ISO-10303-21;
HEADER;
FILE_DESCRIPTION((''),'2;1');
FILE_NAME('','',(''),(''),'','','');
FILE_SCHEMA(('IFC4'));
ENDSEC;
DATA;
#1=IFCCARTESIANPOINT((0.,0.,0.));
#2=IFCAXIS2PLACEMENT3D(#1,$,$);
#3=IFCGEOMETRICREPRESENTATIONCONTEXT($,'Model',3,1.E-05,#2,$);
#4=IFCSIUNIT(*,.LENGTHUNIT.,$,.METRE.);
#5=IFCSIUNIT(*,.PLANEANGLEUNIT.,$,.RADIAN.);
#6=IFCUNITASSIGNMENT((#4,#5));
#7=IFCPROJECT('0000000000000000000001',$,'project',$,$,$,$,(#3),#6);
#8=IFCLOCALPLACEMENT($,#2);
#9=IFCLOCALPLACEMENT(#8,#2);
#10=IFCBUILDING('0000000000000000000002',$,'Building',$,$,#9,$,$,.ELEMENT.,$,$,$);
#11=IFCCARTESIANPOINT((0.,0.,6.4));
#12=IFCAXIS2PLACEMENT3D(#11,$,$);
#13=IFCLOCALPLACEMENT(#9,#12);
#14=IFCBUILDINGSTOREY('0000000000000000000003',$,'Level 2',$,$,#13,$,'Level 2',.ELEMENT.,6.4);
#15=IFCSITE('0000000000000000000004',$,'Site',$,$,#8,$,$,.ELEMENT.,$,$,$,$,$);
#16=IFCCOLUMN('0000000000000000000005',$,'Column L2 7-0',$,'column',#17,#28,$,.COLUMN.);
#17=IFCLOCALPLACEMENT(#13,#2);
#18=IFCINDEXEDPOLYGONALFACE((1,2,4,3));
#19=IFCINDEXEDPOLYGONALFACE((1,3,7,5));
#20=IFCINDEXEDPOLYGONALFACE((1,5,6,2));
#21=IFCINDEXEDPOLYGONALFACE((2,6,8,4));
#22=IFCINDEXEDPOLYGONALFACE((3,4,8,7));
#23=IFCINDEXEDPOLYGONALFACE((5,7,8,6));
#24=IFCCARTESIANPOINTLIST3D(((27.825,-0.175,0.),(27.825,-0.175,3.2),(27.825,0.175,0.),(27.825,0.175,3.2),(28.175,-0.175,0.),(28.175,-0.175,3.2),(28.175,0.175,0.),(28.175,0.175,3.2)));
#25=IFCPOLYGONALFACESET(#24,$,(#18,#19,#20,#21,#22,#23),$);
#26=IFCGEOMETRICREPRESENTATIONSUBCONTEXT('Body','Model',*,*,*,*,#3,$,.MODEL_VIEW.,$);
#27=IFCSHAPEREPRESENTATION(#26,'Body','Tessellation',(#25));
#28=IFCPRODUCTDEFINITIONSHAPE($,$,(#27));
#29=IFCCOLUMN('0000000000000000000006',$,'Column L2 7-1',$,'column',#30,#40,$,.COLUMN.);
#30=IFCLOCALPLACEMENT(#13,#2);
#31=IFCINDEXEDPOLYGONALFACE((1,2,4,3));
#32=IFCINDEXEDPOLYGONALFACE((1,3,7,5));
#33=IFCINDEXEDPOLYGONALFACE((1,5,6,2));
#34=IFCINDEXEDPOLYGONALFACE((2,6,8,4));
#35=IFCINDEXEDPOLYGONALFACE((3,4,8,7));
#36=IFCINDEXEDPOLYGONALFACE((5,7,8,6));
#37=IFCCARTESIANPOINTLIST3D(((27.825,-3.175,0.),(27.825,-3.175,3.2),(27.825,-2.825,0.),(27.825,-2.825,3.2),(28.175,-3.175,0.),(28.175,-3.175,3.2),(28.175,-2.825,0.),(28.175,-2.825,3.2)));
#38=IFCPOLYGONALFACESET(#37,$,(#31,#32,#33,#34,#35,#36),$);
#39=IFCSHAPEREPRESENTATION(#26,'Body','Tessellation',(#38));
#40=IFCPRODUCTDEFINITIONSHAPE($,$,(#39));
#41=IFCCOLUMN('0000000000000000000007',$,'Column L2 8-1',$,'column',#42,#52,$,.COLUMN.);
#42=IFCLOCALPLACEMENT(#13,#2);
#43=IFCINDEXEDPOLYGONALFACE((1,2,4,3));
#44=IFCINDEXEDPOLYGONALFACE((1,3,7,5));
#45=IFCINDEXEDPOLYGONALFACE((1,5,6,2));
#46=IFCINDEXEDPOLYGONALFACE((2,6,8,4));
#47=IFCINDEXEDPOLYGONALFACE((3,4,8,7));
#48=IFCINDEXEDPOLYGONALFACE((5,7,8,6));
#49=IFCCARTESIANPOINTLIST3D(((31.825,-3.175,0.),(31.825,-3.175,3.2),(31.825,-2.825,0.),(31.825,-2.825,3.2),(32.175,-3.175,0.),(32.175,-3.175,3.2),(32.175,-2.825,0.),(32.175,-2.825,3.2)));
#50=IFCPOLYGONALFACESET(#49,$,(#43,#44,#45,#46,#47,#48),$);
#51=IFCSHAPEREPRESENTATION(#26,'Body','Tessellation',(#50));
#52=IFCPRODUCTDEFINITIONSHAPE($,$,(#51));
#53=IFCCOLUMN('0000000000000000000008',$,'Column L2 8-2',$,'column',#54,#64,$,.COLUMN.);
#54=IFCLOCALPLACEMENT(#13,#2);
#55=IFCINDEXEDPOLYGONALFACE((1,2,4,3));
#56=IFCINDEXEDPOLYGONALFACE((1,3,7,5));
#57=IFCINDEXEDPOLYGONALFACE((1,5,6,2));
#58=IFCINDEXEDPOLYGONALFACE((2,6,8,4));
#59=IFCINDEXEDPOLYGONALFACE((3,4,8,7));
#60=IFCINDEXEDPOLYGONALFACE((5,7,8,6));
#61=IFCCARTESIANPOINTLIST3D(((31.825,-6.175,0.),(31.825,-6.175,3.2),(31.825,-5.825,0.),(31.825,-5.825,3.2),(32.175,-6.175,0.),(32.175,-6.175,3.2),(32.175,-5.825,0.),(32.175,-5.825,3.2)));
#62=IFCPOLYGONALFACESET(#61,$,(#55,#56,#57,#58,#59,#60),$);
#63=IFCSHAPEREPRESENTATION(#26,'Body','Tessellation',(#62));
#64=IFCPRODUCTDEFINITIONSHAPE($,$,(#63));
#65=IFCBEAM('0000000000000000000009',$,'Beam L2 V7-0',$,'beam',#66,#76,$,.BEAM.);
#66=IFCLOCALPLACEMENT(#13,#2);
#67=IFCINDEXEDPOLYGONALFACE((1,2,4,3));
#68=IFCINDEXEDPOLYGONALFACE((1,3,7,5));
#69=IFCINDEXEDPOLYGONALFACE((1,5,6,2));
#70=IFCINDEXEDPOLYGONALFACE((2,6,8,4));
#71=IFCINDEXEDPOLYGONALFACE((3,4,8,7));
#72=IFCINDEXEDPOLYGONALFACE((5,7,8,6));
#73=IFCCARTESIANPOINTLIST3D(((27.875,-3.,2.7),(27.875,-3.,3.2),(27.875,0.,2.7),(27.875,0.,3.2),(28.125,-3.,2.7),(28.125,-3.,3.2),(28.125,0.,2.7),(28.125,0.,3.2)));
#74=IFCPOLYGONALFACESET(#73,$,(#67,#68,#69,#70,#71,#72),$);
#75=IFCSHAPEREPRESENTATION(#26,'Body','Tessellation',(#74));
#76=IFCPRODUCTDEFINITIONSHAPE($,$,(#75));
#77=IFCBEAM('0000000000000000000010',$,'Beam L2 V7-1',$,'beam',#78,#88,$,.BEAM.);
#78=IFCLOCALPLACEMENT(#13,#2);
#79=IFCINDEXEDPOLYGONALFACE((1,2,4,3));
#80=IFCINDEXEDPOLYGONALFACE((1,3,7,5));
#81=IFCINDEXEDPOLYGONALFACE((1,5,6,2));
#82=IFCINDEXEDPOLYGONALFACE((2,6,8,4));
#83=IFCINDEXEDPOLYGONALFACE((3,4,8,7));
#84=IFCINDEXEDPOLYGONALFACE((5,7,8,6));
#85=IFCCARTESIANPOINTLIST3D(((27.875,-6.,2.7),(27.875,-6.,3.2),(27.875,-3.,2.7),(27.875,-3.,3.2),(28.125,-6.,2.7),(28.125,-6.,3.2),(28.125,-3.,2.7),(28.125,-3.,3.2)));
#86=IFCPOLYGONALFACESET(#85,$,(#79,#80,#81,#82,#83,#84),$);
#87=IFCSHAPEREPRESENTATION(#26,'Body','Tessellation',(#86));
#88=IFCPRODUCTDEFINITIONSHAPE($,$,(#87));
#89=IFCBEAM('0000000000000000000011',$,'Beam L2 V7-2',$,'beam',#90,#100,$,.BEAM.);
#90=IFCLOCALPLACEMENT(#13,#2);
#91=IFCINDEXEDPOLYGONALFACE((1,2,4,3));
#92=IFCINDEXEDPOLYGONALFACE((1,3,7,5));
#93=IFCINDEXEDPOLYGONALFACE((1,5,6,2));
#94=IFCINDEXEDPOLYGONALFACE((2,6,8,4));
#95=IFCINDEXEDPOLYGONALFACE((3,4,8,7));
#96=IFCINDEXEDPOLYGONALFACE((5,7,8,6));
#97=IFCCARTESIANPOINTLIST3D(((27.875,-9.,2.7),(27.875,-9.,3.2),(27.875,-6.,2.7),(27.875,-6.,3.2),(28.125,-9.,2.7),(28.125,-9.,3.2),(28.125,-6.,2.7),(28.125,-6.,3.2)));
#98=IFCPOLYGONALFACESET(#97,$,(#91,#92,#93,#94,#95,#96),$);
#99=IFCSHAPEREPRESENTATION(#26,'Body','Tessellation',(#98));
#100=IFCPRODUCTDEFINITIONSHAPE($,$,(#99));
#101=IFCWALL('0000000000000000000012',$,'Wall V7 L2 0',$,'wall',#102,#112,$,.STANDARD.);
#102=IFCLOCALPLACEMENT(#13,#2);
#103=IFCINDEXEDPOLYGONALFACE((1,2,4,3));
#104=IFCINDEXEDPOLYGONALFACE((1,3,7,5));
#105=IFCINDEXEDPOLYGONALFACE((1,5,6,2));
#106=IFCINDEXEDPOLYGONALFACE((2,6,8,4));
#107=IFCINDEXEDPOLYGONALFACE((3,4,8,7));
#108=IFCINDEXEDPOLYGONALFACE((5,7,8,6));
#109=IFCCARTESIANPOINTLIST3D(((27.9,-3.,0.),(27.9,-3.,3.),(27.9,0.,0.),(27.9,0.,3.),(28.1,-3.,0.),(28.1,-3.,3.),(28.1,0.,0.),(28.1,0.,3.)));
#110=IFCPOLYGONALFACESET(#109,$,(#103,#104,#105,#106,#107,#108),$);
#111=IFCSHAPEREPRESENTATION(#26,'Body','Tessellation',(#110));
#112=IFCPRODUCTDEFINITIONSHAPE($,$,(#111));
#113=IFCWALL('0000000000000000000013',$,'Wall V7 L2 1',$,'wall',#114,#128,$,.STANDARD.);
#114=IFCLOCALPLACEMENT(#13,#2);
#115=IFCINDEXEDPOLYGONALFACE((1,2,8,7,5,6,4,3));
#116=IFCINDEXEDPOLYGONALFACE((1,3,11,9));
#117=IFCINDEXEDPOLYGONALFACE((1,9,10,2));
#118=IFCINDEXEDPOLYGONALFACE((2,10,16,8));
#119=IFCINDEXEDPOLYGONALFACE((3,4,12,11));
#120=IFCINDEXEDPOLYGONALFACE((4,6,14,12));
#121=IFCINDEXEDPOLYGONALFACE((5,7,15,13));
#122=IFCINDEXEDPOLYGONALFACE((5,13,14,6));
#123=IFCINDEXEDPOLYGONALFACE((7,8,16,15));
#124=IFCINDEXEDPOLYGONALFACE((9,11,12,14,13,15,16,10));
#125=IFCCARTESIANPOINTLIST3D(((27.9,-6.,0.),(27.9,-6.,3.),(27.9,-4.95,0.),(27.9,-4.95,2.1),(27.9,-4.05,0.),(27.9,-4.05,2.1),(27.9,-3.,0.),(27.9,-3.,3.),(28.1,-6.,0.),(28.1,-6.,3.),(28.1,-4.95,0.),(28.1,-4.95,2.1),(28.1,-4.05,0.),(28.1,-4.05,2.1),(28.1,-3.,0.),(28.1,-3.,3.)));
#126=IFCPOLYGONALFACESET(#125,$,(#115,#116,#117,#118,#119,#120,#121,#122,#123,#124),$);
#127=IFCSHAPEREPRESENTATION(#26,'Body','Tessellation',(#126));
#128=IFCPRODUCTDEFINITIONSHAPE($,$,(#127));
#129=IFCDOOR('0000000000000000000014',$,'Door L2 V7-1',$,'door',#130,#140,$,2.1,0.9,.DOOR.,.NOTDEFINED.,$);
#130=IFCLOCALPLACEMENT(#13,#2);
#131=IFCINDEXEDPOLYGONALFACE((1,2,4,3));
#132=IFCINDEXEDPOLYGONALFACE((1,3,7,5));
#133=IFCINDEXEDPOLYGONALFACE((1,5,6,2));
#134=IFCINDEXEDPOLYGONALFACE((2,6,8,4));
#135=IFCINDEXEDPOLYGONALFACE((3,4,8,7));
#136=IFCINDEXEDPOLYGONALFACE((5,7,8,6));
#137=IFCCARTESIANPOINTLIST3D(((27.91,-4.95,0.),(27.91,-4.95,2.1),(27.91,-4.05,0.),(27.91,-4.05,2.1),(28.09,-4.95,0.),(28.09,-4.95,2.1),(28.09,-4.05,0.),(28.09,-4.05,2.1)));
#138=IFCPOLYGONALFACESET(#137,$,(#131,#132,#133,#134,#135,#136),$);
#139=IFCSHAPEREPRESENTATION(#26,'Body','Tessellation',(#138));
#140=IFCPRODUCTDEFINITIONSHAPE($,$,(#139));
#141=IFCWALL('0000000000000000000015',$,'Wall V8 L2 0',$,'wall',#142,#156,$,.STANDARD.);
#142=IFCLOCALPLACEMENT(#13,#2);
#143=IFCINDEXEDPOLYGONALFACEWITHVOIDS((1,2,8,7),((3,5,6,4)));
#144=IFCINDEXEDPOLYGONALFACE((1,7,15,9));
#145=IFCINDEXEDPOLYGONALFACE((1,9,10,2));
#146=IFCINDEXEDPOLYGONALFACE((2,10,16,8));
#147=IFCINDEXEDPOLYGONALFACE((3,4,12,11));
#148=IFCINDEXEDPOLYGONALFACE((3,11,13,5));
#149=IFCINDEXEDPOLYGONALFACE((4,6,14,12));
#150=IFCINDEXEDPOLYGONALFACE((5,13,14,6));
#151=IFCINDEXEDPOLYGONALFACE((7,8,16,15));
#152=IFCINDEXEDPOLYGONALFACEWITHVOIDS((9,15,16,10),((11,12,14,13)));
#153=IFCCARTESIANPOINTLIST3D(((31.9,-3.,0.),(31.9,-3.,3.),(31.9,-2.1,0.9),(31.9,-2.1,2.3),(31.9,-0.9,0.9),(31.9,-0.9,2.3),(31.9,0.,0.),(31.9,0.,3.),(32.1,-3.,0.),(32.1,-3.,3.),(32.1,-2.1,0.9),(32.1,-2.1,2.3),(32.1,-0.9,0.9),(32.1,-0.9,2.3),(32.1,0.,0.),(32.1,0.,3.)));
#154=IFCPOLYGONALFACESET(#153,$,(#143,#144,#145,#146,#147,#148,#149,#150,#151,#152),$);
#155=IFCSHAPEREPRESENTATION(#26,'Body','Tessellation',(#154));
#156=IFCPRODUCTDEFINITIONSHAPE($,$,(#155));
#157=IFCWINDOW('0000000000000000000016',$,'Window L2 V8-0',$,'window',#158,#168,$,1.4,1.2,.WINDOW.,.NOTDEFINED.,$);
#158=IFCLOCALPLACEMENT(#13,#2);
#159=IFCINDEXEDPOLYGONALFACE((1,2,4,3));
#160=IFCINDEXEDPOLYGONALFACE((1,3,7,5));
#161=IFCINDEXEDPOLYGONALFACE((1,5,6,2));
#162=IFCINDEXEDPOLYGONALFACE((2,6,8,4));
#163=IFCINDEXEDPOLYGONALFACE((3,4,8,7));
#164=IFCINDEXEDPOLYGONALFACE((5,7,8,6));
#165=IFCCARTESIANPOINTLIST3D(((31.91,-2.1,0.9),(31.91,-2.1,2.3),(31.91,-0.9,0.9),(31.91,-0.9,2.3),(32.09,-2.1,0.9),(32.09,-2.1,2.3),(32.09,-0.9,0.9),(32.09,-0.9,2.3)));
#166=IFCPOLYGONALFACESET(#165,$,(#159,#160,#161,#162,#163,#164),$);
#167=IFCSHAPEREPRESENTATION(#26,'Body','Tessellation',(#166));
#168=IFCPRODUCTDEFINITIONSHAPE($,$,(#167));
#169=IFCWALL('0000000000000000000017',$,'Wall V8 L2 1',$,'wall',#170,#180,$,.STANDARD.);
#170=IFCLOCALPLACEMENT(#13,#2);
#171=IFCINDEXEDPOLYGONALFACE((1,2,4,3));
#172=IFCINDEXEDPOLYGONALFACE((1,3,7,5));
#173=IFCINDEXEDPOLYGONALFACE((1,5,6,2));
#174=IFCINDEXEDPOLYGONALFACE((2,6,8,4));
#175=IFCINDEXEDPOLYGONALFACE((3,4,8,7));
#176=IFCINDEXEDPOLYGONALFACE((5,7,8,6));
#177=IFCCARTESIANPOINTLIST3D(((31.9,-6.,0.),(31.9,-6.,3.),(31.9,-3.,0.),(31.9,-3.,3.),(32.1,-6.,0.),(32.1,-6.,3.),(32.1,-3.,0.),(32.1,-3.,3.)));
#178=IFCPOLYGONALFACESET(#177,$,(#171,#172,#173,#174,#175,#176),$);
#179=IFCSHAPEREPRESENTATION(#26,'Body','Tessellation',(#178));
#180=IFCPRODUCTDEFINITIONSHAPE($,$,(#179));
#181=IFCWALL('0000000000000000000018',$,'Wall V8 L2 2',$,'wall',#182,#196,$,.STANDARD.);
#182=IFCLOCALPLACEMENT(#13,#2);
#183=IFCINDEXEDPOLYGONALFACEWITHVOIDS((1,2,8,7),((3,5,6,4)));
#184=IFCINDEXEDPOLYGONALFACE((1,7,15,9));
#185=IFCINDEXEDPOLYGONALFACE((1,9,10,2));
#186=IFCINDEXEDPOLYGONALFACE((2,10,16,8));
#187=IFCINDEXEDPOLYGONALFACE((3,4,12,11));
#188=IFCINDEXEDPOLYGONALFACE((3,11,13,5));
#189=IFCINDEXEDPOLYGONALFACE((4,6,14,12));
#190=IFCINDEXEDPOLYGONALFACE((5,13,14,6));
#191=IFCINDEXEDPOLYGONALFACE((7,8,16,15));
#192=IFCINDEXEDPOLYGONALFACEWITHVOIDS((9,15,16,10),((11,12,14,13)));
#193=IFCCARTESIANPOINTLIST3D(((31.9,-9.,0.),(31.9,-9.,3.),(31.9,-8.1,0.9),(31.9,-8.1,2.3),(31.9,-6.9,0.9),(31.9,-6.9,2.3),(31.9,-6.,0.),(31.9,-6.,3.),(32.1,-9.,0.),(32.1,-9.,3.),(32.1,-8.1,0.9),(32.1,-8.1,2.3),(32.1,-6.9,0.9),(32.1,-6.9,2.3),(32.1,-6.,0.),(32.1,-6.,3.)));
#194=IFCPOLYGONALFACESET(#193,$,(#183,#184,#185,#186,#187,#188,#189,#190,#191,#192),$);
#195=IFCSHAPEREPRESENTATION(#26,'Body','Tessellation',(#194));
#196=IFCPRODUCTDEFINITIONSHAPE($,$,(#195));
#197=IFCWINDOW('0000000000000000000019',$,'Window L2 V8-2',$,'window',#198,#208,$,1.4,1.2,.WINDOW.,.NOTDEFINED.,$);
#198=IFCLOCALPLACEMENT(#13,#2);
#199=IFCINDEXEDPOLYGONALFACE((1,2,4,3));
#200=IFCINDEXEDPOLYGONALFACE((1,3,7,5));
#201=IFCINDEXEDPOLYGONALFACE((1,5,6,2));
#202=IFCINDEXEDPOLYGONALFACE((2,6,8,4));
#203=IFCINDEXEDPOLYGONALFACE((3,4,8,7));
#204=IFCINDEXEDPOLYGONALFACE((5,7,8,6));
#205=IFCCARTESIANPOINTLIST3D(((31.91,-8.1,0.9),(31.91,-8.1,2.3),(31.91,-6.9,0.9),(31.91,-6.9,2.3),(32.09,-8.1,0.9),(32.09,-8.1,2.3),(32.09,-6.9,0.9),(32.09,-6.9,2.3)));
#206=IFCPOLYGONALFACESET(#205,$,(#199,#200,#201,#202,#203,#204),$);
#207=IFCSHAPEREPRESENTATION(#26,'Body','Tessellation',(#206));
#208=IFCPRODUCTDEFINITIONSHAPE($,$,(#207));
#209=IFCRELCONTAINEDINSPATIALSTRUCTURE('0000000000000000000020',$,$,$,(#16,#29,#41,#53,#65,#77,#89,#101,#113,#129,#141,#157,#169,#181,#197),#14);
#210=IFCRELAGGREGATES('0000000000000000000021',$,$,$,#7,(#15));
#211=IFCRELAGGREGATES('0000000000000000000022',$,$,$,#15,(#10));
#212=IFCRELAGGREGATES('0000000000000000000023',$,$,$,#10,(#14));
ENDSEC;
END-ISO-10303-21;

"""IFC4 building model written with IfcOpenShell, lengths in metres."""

from ifc_helpers import new_model, si_unit, frame, frame_2d, origin, origin_2d, place, context, subcontext, project, spatial, rectangle, extrude, element, fill, save


model = new_model("IFC4")

# Units and contexts
model_context = context("Model", 3, precision=1e-05, world=origin())
body_context = subcontext(model_context, "Body", "Model", "MODEL_VIEW")
ifc_project = project(units=[si_unit("LENGTHUNIT", "METRE"), si_unit("PLANEANGLEUNIT", "RADIAN")], contexts=[model_context])

# Site, building, storey
site_placement = place(None, origin())
site = spatial("IfcSite", under=ifc_project, at=site_placement, Name="Site", CompositionType="ELEMENT")
building_placement = place(site_placement, origin())
building = spatial("IfcBuilding", under=site, at=building_placement, Name="Building", CompositionType="ELEMENT")
storey_placement = place(building_placement, frame((0.0, 0.0, 6.4)))
storey = spatial("IfcBuildingStorey", under=building, at=storey_placement, Name="Level 2", LongName="Level 2", CompositionType="ELEMENT", Elevation=6.4)

# Columns
for number, where, name in (
    (1, (28.0, 0.0, 0.0), "Column L2 7-0"),
    (2, (28.0, -3.0, 0.0), "Column L2 7-1"),
    (3, (32.0, -3.0, 0.0), "Column L2 8-1"),
    (4, (32.0, -6.0, 0.0), "Column L2 8-2"),
):
    element("IfcColumn", number, at=place(storey_placement, frame(where)), inside=storey, Name=name, ObjectType="column", PredefinedType="COLUMN", context=body_context, shape_type="SweptSolid", body=[
        extrude(rectangle(XDim=0.35, YDim=0.35, at=origin_2d()), origin(), (0.0, 0.0, 1.0), 3.2),
    ])

# Beams
for number, where, z_axis, x_axis, name in (
    (5, (28.0, 0.0, 2.95), (0.0, -1.0, 0.0), (0.0, 0.0, 1.0), "Beam L2 V7-0"),
    (6, (28.0, -3.0, 2.95), (0.0, -1.0, 0.0), (0.0, 0.0, 1.0), "Beam L2 V7-1"),
    (7, (28.0, -6.0, 2.95), (0.0, -1.0, 0.0), (0.0, 0.0, 1.0), "Beam L2 V7-2"),
):
    element("IfcBeam", number, at=place(storey_placement, frame(where, z_axis=z_axis, x_axis=x_axis)), inside=storey, Name=name, ObjectType="beam", PredefinedType="BEAM", context=body_context, shape_type="SweptSolid", body=[
        extrude(rectangle(XDim=0.5, YDim=0.25, at=origin_2d()), origin(), (0.0, 0.0, 1.0), 3.0),
    ])

# Wall
wall_1_placement = place(storey_placement, frame((28.0, 0.0, 0.0), z_axis=(0.0, 0.0, 1.0), x_axis=(0.0, -1.0, 0.0)))
element("IfcWall", 8, at=wall_1_placement, inside=storey, Name="Wall V7 L2 0", ObjectType="wall", PredefinedType="STANDARD", context=body_context, shape_type="SweptSolid", body=[
    extrude(rectangle(XDim=3.0, YDim=0.2, at=frame_2d((1.5, 0.0))), origin(), (0.0, 0.0, 1.0), 3.0),
])

# Wall, opening, door
wall_2_placement = place(storey_placement, frame((28.0, -3.0, 0.0), z_axis=(0.0, 0.0, 1.0), x_axis=(0.0, -1.0, 0.0)))
wall_2 = element("IfcWall", 9, at=wall_2_placement, inside=storey, Name="Wall V7 L2 1", ObjectType="wall", PredefinedType="STANDARD", context=body_context, shape_type="SweptSolid", body=[
    extrude(rectangle(XDim=3.0, YDim=0.2, at=frame_2d((1.5, 0.0))), origin(), (0.0, 0.0, 1.0), 3.0),
])
opening_1_placement = place(storey_placement, frame((28.0, -4.5, 0.0), z_axis=(0.0, 0.0, 1.0), x_axis=(0.0, -1.0, 0.0)))
opening_1 = element("IfcOpeningElement", 10, at=opening_1_placement, cuts=wall_2, ObjectType="Opening", PredefinedType="OPENING", context=body_context, shape_type="SweptSolid", body=[
    extrude(rectangle(XDim=0.9, YDim=0.22, at=origin_2d()), origin(), (0.0, 0.0, 1.0), 2.1),
])
door_placement = place(storey_placement, frame((28.0, -4.5, 0.0), z_axis=(0.0, 0.0, 1.0), x_axis=(0.0, -1.0, 0.0)))
door = element("IfcDoor", 11, at=door_placement, inside=storey, Name="Door L2 V7-1", ObjectType="door", OperationType="NOTDEFINED", OverallHeight=2.1, OverallWidth=0.9, PredefinedType="DOOR", context=body_context, shape_type="SweptSolid", body=[
    extrude(rectangle(XDim=0.9, YDim=0.18, at=origin_2d()), origin(), (0.0, 0.0, 1.0), 2.1),
])
fill(opening_1, door)

# Wall, opening, window
wall_3_placement = place(storey_placement, frame((32.0, 0.0, 0.0), z_axis=(0.0, 0.0, 1.0), x_axis=(0.0, -1.0, 0.0)))
wall_3 = element("IfcWall", 12, at=wall_3_placement, inside=storey, Name="Wall V8 L2 0", ObjectType="wall", PredefinedType="STANDARD", context=body_context, shape_type="SweptSolid", body=[
    extrude(rectangle(XDim=3.0, YDim=0.2, at=frame_2d((1.5, 0.0))), origin(), (0.0, 0.0, 1.0), 3.0),
])
opening_2_placement = place(storey_placement, frame((32.0, -1.5, 0.9), z_axis=(0.0, 0.0, 1.0), x_axis=(0.0, -1.0, 0.0)))
opening_2 = element("IfcOpeningElement", 13, at=opening_2_placement, cuts=wall_3, ObjectType="Opening", PredefinedType="OPENING", context=body_context, shape_type="SweptSolid", body=[
    extrude(rectangle(XDim=1.2, YDim=0.22, at=origin_2d()), origin(), (0.0, 0.0, 1.0), 1.4),
])
window_1_placement = place(storey_placement, frame((32.0, -1.5, 0.9), z_axis=(0.0, 0.0, 1.0), x_axis=(0.0, -1.0, 0.0)))
window_1 = element("IfcWindow", 14, at=window_1_placement, inside=storey, Name="Window L2 V8-0", ObjectType="window", OverallHeight=1.4, OverallWidth=1.2, PartitioningType="NOTDEFINED", PredefinedType="WINDOW", context=body_context, shape_type="SweptSolid", body=[
    extrude(rectangle(XDim=1.2, YDim=0.18, at=origin_2d()), origin(), (0.0, 0.0, 1.0), 1.4),
])
fill(opening_2, window_1)

# Wall
wall_4_placement = place(storey_placement, frame((32.0, -3.0, 0.0), z_axis=(0.0, 0.0, 1.0), x_axis=(0.0, -1.0, 0.0)))
element("IfcWall", 15, at=wall_4_placement, inside=storey, Name="Wall V8 L2 1", ObjectType="wall", PredefinedType="STANDARD", context=body_context, shape_type="SweptSolid", body=[
    extrude(rectangle(XDim=3.0, YDim=0.2, at=frame_2d((1.5, 0.0))), origin(), (0.0, 0.0, 1.0), 3.0),
])

# Wall, opening, window
wall_5_placement = place(storey_placement, frame((32.0, -6.0, 0.0), z_axis=(0.0, 0.0, 1.0), x_axis=(0.0, -1.0, 0.0)))
wall_5 = element("IfcWall", 16, at=wall_5_placement, inside=storey, Name="Wall V8 L2 2", ObjectType="wall", PredefinedType="STANDARD", context=body_context, shape_type="SweptSolid", body=[
    extrude(rectangle(XDim=3.0, YDim=0.2, at=frame_2d((1.5, 0.0))), origin(), (0.0, 0.0, 1.0), 3.0),
])
opening_3_placement = place(storey_placement, frame((32.0, -7.5, 0.9), z_axis=(0.0, 0.0, 1.0), x_axis=(0.0, -1.0, 0.0)))
opening_3 = element("IfcOpeningElement", 17, at=opening_3_placement, cuts=wall_5, ObjectType="Opening", PredefinedType="OPENING", context=body_context, shape_type="SweptSolid", body=[
    extrude(rectangle(XDim=1.2, YDim=0.22, at=origin_2d()), origin(), (0.0, 0.0, 1.0), 1.4),
])
window_2_placement = place(storey_placement, frame((32.0, -7.5, 0.9), z_axis=(0.0, 0.0, 1.0), x_axis=(0.0, -1.0, 0.0)))
window_2 = element("IfcWindow", 18, at=window_2_placement, inside=storey, Name="Window L2 V8-2", ObjectType="window", OverallHeight=1.4, OverallWidth=1.2, PartitioningType="NOTDEFINED", PredefinedType="WINDOW", context=body_context, shape_type="SweptSolid", body=[
    extrude(rectangle(XDim=1.2, YDim=0.18, at=origin_2d()), origin(), (0.0, 0.0, 1.0), 1.4),
])
fill(opening_3, window_2)

save(model, "model.ifc")
